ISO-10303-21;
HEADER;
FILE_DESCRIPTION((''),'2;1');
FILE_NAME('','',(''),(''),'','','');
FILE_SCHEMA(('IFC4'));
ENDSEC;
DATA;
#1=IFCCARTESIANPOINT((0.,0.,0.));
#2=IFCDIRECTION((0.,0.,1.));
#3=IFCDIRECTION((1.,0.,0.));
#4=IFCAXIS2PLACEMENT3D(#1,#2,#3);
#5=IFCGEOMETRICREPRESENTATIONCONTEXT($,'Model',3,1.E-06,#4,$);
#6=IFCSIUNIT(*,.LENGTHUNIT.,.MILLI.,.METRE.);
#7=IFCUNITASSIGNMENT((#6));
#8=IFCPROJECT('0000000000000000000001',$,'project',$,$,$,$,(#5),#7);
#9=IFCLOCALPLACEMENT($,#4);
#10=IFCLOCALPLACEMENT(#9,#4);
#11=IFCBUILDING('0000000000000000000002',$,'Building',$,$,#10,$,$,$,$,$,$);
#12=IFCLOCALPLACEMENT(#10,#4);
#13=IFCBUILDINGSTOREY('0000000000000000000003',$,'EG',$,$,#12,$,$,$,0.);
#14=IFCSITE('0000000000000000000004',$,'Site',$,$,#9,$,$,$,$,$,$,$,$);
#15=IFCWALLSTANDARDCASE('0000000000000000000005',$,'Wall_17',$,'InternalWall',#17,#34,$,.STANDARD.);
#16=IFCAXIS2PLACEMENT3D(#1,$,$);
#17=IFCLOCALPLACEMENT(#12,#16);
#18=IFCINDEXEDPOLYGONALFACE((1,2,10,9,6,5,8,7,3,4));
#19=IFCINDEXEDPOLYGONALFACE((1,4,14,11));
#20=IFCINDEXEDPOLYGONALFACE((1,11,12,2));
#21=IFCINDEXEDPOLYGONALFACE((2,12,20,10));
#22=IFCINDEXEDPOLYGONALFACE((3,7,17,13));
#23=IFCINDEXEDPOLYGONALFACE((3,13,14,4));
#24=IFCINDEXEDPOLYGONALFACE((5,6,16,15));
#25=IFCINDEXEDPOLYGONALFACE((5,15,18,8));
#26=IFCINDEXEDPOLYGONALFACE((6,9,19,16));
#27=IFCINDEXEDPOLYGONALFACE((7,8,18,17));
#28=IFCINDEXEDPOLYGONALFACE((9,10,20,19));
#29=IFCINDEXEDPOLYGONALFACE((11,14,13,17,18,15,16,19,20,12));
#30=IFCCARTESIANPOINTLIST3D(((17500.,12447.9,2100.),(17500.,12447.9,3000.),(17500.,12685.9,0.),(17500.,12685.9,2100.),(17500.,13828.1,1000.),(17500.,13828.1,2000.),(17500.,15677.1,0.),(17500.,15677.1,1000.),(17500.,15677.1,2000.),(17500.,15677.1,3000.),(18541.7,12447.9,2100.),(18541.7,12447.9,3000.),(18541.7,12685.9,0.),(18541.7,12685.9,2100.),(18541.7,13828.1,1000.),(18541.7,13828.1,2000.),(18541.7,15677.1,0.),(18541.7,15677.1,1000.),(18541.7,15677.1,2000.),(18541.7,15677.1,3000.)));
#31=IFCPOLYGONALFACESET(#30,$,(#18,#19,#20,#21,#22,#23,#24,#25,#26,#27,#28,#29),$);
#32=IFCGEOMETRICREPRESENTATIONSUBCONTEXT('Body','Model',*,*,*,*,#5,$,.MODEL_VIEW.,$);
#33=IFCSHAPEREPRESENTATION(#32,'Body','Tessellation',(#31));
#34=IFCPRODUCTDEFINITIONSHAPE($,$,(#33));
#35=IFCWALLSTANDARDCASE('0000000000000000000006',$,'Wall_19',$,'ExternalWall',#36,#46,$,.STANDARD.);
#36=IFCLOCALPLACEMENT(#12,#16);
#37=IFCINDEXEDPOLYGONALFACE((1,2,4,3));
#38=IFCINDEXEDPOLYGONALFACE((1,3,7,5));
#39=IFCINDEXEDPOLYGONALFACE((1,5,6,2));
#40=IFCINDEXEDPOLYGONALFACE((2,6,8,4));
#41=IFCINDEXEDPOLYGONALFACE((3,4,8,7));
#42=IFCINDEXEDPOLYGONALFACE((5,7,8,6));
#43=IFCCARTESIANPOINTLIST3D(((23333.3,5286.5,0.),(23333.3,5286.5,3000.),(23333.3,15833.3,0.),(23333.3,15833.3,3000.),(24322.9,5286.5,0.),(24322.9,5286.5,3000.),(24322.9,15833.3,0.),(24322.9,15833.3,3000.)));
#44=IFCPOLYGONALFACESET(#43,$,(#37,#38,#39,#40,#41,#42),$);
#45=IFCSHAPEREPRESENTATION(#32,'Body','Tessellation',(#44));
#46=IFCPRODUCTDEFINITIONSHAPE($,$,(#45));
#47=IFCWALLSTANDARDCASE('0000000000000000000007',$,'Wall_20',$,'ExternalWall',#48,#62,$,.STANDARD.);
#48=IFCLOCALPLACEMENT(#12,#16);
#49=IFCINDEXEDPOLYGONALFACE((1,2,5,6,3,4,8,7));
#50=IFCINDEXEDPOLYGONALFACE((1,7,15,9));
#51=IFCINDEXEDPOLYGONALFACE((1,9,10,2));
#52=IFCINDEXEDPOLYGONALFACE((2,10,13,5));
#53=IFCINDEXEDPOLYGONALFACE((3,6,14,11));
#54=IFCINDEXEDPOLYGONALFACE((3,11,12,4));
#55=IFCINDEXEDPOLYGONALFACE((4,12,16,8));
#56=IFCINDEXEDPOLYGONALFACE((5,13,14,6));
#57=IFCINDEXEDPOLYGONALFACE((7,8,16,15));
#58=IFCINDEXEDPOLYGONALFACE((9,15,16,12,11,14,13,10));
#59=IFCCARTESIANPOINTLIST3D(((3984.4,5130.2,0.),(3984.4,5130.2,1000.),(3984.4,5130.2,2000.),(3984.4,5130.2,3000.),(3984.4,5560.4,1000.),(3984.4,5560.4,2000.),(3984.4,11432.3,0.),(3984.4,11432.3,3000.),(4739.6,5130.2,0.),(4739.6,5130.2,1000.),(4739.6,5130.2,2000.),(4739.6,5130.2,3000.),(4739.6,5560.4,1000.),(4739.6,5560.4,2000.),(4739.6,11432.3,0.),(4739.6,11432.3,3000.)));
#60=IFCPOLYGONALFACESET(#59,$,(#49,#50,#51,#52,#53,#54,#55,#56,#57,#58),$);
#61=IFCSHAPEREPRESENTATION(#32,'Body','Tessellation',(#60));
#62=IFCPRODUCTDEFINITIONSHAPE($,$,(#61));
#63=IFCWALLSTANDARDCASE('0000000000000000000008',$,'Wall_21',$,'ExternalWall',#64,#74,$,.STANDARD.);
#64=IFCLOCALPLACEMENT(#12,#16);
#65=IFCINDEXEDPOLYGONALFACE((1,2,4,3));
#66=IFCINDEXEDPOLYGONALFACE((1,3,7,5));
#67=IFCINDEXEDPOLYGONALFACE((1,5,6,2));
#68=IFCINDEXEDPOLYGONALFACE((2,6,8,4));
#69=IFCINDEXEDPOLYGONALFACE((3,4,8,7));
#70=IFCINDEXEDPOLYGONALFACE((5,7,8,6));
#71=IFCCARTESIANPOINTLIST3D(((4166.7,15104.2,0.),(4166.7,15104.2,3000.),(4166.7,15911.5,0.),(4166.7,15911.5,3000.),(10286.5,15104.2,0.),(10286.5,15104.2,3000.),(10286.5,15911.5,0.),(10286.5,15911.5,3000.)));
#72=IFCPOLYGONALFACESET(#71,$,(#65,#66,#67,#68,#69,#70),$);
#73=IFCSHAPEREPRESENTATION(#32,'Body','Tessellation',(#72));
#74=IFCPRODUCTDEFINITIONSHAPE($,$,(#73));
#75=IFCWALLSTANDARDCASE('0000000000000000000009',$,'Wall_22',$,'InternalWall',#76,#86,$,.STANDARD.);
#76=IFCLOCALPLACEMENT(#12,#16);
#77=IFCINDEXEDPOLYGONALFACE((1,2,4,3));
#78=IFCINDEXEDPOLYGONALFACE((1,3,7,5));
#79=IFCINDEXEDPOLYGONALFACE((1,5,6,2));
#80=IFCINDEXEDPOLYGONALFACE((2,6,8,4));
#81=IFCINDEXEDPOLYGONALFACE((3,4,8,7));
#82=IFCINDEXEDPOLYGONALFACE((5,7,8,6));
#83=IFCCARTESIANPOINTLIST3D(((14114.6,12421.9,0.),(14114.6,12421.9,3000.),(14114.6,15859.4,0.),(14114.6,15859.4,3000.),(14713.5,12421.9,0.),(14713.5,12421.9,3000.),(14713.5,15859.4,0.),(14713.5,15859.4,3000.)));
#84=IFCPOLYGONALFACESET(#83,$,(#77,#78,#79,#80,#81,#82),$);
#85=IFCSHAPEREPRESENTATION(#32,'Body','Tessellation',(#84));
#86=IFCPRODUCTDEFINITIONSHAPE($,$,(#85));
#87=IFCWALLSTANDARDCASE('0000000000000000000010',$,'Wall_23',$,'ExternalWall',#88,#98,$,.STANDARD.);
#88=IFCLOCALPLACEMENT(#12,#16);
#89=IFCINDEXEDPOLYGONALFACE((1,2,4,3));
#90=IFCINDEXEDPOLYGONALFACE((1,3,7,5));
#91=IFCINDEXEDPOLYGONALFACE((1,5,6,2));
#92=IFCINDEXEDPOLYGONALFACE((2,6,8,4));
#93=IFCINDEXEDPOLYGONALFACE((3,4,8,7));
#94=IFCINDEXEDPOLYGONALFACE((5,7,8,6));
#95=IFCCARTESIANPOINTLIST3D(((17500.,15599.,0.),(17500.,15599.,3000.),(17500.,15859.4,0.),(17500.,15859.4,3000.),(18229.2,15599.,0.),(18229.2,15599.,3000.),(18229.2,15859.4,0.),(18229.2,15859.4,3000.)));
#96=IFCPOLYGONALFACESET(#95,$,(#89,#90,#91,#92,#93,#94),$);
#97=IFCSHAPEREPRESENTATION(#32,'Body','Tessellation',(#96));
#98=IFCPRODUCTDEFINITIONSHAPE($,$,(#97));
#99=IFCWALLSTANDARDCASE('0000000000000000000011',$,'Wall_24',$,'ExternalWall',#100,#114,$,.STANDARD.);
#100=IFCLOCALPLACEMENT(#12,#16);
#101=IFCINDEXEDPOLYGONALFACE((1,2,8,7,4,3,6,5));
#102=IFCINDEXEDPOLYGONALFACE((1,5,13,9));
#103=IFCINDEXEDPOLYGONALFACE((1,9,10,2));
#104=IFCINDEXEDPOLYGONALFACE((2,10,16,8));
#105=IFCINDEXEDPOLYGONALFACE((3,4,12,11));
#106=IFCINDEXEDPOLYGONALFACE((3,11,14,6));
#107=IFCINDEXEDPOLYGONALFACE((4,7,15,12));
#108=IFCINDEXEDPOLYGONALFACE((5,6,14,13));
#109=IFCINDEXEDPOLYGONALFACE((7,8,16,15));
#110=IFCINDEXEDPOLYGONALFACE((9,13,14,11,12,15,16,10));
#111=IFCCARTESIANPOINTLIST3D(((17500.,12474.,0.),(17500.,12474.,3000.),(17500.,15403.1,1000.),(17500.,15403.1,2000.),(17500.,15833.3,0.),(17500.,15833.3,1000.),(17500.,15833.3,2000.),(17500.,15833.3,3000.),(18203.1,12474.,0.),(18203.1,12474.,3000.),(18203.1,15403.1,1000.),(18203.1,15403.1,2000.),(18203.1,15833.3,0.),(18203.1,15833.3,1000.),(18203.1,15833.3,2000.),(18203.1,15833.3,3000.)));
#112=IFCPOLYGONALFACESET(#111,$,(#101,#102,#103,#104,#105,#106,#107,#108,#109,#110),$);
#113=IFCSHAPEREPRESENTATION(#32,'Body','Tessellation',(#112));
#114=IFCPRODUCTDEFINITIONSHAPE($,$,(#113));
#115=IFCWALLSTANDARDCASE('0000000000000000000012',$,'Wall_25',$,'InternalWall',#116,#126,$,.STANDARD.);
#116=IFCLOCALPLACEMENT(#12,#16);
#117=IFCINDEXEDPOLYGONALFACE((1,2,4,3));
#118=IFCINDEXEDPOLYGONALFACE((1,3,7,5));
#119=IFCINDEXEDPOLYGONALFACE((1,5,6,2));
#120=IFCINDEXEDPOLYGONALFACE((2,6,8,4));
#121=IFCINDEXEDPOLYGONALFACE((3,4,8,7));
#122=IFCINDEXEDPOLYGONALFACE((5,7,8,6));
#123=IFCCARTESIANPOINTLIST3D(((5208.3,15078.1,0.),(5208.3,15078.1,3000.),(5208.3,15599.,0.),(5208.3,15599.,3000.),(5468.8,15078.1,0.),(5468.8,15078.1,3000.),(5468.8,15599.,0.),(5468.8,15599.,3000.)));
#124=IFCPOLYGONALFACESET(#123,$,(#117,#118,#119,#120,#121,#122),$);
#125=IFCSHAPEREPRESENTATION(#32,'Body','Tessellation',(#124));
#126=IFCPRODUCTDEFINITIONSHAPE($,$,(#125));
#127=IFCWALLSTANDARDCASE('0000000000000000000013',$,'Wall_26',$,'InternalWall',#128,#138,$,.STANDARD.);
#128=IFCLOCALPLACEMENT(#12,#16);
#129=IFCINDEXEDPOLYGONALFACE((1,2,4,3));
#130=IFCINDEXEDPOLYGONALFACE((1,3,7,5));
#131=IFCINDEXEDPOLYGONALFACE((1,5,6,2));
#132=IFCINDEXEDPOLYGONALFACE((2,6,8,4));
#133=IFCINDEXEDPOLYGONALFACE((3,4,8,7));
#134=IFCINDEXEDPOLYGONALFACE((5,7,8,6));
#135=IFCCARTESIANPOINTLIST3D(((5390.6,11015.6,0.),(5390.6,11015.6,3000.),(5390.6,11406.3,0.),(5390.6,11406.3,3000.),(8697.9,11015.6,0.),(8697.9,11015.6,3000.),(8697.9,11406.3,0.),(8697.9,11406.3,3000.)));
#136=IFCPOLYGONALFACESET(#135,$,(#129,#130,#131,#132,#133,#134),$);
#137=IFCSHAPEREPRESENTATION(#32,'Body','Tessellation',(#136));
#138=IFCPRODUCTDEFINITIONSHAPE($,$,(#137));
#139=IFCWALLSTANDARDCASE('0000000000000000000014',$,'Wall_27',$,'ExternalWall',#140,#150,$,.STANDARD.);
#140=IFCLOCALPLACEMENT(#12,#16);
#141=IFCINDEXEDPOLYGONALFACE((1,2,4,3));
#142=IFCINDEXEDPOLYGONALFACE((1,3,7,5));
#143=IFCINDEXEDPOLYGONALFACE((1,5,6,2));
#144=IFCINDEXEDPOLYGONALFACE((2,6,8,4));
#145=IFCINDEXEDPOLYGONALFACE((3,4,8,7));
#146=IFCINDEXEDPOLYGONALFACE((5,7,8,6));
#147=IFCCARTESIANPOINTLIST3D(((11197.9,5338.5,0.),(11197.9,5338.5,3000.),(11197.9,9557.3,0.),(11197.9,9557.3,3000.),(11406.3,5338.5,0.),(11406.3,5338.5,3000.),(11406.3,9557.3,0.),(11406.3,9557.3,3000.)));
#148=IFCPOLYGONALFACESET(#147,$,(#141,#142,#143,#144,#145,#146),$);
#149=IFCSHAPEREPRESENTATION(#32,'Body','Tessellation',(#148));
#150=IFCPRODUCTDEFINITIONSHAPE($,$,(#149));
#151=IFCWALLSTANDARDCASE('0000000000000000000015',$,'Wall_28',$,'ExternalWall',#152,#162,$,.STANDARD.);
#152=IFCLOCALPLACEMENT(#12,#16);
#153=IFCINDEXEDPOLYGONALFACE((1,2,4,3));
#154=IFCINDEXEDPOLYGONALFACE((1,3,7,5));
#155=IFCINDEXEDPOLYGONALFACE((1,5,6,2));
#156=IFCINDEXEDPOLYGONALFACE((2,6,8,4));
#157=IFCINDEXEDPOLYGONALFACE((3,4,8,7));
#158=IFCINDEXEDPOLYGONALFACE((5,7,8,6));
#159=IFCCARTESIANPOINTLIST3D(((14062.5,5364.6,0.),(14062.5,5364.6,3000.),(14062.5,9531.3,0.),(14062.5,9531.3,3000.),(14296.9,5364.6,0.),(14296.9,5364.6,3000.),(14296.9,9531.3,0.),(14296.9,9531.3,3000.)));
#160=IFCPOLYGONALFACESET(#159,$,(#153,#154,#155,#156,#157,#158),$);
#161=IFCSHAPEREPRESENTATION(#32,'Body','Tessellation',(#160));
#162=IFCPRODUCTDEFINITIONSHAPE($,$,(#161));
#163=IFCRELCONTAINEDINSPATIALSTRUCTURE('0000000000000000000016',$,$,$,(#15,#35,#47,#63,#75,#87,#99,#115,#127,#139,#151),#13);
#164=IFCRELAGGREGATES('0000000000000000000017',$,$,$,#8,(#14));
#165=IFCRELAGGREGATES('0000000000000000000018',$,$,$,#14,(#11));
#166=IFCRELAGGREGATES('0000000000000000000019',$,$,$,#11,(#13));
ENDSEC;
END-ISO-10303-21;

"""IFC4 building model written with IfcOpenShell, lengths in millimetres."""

from ifc_helpers import new_model, si_unit, frame, origin_with_axes, place, context, subcontext, project, spatial, rectangle, extrude, element, save


model = new_model("IFC4")

# Units and contexts
model_context = context("Model", 3, precision=1e-06, world=origin_with_axes())
body_context = subcontext(model_context, "Body", "Model", "MODEL_VIEW")
ifc_project = project(units=[si_unit("LENGTHUNIT", "METRE", prefix="MILLI")], contexts=[model_context])

# Site, building, storey
site_placement = place(None, origin_with_axes())
site = spatial("IfcSite", under=ifc_project, at=site_placement, Name="Site")
building_placement = place(site_placement, origin_with_axes())
building = spatial("IfcBuilding", under=site, at=building_placement, Name="Building")
storey_placement = place(building_placement, origin_with_axes())
storey = spatial("IfcBuildingStorey", under=building, at=storey_placement, Name="EG", Elevation=0.0)

# Wall, openings
wall_1_placement = place(storey_placement, origin_with_axes())
wall_1 = element("IfcWallStandardCase", 1, at=wall_1_placement, inside=storey, Name="Wall_17", ObjectType="InternalWall", PredefinedType="STANDARD", context=body_context, shape_type="SweptSolid", body=[
    extrude(rectangle(XDim=3229.2, YDim=1041.7), frame((18020.8, 14062.5, 0.0), z_axis=(0.0, 0.0, 1.0), x_axis=(0.0, 1.0, 0.0)), (0.0, 0.0, 1.0), 3000.0),
])
opening_1_placement = place(wall_1_placement, origin_with_axes())
element("IfcOpeningElement", 2, at=opening_1_placement, inside=storey, cuts=wall_1, context=body_context, shape_type="SweptSolid", body=[
    extrude(rectangle(XDim=450.0, YDim=1041.7), frame((18020.8, 12460.9, 0.0), z_axis=(0.0, 0.0, 1.0), x_axis=(0.0, 1.0, 0.0)), (0.0, 0.0, 1.0), 2100.0),
])
opening_2_placement = place(wall_1_placement, origin_with_axes())
element("IfcOpeningElement", 3, at=opening_2_placement, inside=storey, cuts=wall_1, context=body_context, shape_type="SweptSolid", body=[
    extrude(rectangle(XDim=1849.0, YDim=1041.7), frame((18020.8, 14752.6, 1000.0), z_axis=(0.0, 0.0, 1.0), x_axis=(0.0, 1.0, 0.0)), (0.0, 0.0, 1.0), 1000.0),
])

# Wall
wall_2_placement = place(storey_placement, origin_with_axes())
element("IfcWallStandardCase", 4, at=wall_2_placement, inside=storey, Name="Wall_19", ObjectType="ExternalWall", PredefinedType="STANDARD", context=body_context, shape_type="SweptSolid", body=[
    extrude(rectangle(XDim=10546.9, YDim=989.6), frame((23828.1, 10559.9, 0.0), z_axis=(0.0, 0.0, 1.0), x_axis=(0.0, 1.0, 0.0)), (0.0, 0.0, 1.0), 3000.0),
])

# Wall, opening
wall_3_placement = place(storey_placement, origin_with_axes())
wall_3 = element("IfcWallStandardCase", 5, at=wall_3_placement, inside=storey, Name="Wall_20", ObjectType="ExternalWall", PredefinedType="STANDARD", context=body_context, shape_type="SweptSolid", body=[
    extrude(rectangle(XDim=6302.1, YDim=755.2), frame((4362.0, 8281.3, 0.0), z_axis=(0.0, 0.0, 1.0), x_axis=(0.0, 1.0, 0.0)), (0.0, 0.0, 1.0), 3000.0),
])
opening_3_placement = place(wall_3_placement, origin_with_axes())
element("IfcOpeningElement", 6, at=opening_3_placement, inside=storey, cuts=wall_3, context=body_context, shape_type="SweptSolid", body=[
    extrude(rectangle(XDim=600.0, YDim=755.2), frame((4362.0, 5260.4, 1000.0), z_axis=(0.0, 0.0, 1.0), x_axis=(0.0, 1.0, 0.0)), (0.0, 0.0, 1.0), 1000.0),
])

# Walls
wall_4_placement = place(storey_placement, origin_with_axes())
element("IfcWallStandardCase", 7, at=wall_4_placement, inside=storey, Name="Wall_21", ObjectType="ExternalWall", PredefinedType="STANDARD", context=body_context, shape_type="SweptSolid", body=[
    extrude(rectangle(XDim=6119.8, YDim=807.3), frame((7226.6, 15507.8, 0.0), z_axis=(0.0, 0.0, 1.0), x_axis=(-1.0, 0.0, 0.0)), (0.0, 0.0, 1.0), 3000.0),
])
wall_5_placement = place(storey_placement, origin_with_axes())
element("IfcWallStandardCase", 8, at=wall_5_placement, inside=storey, Name="Wall_22", ObjectType="InternalWall", PredefinedType="STANDARD", context=body_context, shape_type="SweptSolid", body=[
    extrude(rectangle(XDim=3437.5, YDim=599.0), frame((14414.1, 14140.6, 0.0), z_axis=(0.0, 0.0, 1.0), x_axis=(0.0, 1.0, 0.0)), (0.0, 0.0, 1.0), 3000.0),
])
wall_6_placement = place(storey_placement, origin_with_axes())
element("IfcWallStandardCase", 9, at=wall_6_placement, inside=storey, Name="Wall_23", ObjectType="ExternalWall", PredefinedType="STANDARD", context=body_context, shape_type="SweptSolid", body=[
    extrude(rectangle(XDim=729.2, YDim=260.4), frame((17864.6, 15729.2, 0.0), z_axis=(0.0, 0.0, 1.0), x_axis=(1.0, 0.0, 0.0)), (0.0, 0.0, 1.0), 3000.0),
])

# Wall, opening
wall_7_placement = place(storey_placement, origin_with_axes())
wall_7 = element("IfcWallStandardCase", 10, at=wall_7_placement, inside=storey, Name="Wall_24", ObjectType="ExternalWall", PredefinedType="STANDARD", context=body_context, shape_type="SweptSolid", body=[
    extrude(rectangle(XDim=3359.4, YDim=703.1), frame((17851.6, 14153.6, 0.0), z_axis=(0.0, 0.0, 1.0), x_axis=(0.0, 1.0, 0.0)), (0.0, 0.0, 1.0), 3000.0),
])
opening_4_placement = place(wall_7_placement, origin_with_axes())
element("IfcOpeningElement", 11, at=opening_4_placement, inside=storey, cuts=wall_7, context=body_context, shape_type="SweptSolid", body=[
    extrude(rectangle(XDim=600.0, YDim=703.1), frame((17851.6, 15703.1, 1000.0), z_axis=(0.0, 0.0, 1.0), x_axis=(0.0, 1.0, 0.0)), (0.0, 0.0, 1.0), 1000.0),
])

# Walls
wall_8_placement = place(storey_placement, origin_with_axes())
element("IfcWallStandardCase", 12, at=wall_8_placement, inside=storey, Name="Wall_25", ObjectType="InternalWall", PredefinedType="STANDARD", context=body_context, shape_type="SweptSolid", body=[
    extrude(rectangle(XDim=520.8, YDim=260.4), frame((5338.5, 15338.5, 0.0), z_axis=(0.0, 0.0, 1.0), x_axis=(0.0, 1.0, 0.0)), (0.0, 0.0, 1.0), 3000.0),
])
wall_9_placement = place(storey_placement, origin_with_axes())
element("IfcWallStandardCase", 13, at=wall_9_placement, inside=storey, Name="Wall_26", ObjectType="InternalWall", PredefinedType="STANDARD", context=body_context, shape_type="SweptSolid", body=[
    extrude(rectangle(XDim=3307.3, YDim=390.6), frame((7044.3, 11210.9, 0.0), z_axis=(0.0, 0.0, 1.0), x_axis=(1.0, 0.0, 0.0)), (0.0, 0.0, 1.0), 3000.0),
])
wall_10_placement = place(storey_placement, origin_with_axes())
element("IfcWallStandardCase", 14, at=wall_10_placement, inside=storey, Name="Wall_27", ObjectType="ExternalWall", PredefinedType="STANDARD", context=body_context, shape_type="SweptSolid", body=[
    extrude(rectangle(XDim=4218.8, YDim=208.3), frame((11302.1, 7447.9, 0.0), z_axis=(0.0, 0.0, 1.0), x_axis=(0.0, 1.0, 0.0)), (0.0, 0.0, 1.0), 3000.0),
])
wall_11_placement = place(storey_placement, origin_with_axes())
element("IfcWallStandardCase", 15, at=wall_11_placement, inside=storey, Name="Wall_28", ObjectType="ExternalWall", PredefinedType="STANDARD", context=body_context, shape_type="SweptSolid", body=[
    extrude(rectangle(XDim=4166.7, YDim=234.4), frame((14179.7, 7447.9, 0.0), z_axis=(0.0, 0.0, 1.0), x_axis=(0.0, 1.0, 0.0)), (0.0, 0.0, 1.0), 3000.0),
])

save(model, "model.ifc")
